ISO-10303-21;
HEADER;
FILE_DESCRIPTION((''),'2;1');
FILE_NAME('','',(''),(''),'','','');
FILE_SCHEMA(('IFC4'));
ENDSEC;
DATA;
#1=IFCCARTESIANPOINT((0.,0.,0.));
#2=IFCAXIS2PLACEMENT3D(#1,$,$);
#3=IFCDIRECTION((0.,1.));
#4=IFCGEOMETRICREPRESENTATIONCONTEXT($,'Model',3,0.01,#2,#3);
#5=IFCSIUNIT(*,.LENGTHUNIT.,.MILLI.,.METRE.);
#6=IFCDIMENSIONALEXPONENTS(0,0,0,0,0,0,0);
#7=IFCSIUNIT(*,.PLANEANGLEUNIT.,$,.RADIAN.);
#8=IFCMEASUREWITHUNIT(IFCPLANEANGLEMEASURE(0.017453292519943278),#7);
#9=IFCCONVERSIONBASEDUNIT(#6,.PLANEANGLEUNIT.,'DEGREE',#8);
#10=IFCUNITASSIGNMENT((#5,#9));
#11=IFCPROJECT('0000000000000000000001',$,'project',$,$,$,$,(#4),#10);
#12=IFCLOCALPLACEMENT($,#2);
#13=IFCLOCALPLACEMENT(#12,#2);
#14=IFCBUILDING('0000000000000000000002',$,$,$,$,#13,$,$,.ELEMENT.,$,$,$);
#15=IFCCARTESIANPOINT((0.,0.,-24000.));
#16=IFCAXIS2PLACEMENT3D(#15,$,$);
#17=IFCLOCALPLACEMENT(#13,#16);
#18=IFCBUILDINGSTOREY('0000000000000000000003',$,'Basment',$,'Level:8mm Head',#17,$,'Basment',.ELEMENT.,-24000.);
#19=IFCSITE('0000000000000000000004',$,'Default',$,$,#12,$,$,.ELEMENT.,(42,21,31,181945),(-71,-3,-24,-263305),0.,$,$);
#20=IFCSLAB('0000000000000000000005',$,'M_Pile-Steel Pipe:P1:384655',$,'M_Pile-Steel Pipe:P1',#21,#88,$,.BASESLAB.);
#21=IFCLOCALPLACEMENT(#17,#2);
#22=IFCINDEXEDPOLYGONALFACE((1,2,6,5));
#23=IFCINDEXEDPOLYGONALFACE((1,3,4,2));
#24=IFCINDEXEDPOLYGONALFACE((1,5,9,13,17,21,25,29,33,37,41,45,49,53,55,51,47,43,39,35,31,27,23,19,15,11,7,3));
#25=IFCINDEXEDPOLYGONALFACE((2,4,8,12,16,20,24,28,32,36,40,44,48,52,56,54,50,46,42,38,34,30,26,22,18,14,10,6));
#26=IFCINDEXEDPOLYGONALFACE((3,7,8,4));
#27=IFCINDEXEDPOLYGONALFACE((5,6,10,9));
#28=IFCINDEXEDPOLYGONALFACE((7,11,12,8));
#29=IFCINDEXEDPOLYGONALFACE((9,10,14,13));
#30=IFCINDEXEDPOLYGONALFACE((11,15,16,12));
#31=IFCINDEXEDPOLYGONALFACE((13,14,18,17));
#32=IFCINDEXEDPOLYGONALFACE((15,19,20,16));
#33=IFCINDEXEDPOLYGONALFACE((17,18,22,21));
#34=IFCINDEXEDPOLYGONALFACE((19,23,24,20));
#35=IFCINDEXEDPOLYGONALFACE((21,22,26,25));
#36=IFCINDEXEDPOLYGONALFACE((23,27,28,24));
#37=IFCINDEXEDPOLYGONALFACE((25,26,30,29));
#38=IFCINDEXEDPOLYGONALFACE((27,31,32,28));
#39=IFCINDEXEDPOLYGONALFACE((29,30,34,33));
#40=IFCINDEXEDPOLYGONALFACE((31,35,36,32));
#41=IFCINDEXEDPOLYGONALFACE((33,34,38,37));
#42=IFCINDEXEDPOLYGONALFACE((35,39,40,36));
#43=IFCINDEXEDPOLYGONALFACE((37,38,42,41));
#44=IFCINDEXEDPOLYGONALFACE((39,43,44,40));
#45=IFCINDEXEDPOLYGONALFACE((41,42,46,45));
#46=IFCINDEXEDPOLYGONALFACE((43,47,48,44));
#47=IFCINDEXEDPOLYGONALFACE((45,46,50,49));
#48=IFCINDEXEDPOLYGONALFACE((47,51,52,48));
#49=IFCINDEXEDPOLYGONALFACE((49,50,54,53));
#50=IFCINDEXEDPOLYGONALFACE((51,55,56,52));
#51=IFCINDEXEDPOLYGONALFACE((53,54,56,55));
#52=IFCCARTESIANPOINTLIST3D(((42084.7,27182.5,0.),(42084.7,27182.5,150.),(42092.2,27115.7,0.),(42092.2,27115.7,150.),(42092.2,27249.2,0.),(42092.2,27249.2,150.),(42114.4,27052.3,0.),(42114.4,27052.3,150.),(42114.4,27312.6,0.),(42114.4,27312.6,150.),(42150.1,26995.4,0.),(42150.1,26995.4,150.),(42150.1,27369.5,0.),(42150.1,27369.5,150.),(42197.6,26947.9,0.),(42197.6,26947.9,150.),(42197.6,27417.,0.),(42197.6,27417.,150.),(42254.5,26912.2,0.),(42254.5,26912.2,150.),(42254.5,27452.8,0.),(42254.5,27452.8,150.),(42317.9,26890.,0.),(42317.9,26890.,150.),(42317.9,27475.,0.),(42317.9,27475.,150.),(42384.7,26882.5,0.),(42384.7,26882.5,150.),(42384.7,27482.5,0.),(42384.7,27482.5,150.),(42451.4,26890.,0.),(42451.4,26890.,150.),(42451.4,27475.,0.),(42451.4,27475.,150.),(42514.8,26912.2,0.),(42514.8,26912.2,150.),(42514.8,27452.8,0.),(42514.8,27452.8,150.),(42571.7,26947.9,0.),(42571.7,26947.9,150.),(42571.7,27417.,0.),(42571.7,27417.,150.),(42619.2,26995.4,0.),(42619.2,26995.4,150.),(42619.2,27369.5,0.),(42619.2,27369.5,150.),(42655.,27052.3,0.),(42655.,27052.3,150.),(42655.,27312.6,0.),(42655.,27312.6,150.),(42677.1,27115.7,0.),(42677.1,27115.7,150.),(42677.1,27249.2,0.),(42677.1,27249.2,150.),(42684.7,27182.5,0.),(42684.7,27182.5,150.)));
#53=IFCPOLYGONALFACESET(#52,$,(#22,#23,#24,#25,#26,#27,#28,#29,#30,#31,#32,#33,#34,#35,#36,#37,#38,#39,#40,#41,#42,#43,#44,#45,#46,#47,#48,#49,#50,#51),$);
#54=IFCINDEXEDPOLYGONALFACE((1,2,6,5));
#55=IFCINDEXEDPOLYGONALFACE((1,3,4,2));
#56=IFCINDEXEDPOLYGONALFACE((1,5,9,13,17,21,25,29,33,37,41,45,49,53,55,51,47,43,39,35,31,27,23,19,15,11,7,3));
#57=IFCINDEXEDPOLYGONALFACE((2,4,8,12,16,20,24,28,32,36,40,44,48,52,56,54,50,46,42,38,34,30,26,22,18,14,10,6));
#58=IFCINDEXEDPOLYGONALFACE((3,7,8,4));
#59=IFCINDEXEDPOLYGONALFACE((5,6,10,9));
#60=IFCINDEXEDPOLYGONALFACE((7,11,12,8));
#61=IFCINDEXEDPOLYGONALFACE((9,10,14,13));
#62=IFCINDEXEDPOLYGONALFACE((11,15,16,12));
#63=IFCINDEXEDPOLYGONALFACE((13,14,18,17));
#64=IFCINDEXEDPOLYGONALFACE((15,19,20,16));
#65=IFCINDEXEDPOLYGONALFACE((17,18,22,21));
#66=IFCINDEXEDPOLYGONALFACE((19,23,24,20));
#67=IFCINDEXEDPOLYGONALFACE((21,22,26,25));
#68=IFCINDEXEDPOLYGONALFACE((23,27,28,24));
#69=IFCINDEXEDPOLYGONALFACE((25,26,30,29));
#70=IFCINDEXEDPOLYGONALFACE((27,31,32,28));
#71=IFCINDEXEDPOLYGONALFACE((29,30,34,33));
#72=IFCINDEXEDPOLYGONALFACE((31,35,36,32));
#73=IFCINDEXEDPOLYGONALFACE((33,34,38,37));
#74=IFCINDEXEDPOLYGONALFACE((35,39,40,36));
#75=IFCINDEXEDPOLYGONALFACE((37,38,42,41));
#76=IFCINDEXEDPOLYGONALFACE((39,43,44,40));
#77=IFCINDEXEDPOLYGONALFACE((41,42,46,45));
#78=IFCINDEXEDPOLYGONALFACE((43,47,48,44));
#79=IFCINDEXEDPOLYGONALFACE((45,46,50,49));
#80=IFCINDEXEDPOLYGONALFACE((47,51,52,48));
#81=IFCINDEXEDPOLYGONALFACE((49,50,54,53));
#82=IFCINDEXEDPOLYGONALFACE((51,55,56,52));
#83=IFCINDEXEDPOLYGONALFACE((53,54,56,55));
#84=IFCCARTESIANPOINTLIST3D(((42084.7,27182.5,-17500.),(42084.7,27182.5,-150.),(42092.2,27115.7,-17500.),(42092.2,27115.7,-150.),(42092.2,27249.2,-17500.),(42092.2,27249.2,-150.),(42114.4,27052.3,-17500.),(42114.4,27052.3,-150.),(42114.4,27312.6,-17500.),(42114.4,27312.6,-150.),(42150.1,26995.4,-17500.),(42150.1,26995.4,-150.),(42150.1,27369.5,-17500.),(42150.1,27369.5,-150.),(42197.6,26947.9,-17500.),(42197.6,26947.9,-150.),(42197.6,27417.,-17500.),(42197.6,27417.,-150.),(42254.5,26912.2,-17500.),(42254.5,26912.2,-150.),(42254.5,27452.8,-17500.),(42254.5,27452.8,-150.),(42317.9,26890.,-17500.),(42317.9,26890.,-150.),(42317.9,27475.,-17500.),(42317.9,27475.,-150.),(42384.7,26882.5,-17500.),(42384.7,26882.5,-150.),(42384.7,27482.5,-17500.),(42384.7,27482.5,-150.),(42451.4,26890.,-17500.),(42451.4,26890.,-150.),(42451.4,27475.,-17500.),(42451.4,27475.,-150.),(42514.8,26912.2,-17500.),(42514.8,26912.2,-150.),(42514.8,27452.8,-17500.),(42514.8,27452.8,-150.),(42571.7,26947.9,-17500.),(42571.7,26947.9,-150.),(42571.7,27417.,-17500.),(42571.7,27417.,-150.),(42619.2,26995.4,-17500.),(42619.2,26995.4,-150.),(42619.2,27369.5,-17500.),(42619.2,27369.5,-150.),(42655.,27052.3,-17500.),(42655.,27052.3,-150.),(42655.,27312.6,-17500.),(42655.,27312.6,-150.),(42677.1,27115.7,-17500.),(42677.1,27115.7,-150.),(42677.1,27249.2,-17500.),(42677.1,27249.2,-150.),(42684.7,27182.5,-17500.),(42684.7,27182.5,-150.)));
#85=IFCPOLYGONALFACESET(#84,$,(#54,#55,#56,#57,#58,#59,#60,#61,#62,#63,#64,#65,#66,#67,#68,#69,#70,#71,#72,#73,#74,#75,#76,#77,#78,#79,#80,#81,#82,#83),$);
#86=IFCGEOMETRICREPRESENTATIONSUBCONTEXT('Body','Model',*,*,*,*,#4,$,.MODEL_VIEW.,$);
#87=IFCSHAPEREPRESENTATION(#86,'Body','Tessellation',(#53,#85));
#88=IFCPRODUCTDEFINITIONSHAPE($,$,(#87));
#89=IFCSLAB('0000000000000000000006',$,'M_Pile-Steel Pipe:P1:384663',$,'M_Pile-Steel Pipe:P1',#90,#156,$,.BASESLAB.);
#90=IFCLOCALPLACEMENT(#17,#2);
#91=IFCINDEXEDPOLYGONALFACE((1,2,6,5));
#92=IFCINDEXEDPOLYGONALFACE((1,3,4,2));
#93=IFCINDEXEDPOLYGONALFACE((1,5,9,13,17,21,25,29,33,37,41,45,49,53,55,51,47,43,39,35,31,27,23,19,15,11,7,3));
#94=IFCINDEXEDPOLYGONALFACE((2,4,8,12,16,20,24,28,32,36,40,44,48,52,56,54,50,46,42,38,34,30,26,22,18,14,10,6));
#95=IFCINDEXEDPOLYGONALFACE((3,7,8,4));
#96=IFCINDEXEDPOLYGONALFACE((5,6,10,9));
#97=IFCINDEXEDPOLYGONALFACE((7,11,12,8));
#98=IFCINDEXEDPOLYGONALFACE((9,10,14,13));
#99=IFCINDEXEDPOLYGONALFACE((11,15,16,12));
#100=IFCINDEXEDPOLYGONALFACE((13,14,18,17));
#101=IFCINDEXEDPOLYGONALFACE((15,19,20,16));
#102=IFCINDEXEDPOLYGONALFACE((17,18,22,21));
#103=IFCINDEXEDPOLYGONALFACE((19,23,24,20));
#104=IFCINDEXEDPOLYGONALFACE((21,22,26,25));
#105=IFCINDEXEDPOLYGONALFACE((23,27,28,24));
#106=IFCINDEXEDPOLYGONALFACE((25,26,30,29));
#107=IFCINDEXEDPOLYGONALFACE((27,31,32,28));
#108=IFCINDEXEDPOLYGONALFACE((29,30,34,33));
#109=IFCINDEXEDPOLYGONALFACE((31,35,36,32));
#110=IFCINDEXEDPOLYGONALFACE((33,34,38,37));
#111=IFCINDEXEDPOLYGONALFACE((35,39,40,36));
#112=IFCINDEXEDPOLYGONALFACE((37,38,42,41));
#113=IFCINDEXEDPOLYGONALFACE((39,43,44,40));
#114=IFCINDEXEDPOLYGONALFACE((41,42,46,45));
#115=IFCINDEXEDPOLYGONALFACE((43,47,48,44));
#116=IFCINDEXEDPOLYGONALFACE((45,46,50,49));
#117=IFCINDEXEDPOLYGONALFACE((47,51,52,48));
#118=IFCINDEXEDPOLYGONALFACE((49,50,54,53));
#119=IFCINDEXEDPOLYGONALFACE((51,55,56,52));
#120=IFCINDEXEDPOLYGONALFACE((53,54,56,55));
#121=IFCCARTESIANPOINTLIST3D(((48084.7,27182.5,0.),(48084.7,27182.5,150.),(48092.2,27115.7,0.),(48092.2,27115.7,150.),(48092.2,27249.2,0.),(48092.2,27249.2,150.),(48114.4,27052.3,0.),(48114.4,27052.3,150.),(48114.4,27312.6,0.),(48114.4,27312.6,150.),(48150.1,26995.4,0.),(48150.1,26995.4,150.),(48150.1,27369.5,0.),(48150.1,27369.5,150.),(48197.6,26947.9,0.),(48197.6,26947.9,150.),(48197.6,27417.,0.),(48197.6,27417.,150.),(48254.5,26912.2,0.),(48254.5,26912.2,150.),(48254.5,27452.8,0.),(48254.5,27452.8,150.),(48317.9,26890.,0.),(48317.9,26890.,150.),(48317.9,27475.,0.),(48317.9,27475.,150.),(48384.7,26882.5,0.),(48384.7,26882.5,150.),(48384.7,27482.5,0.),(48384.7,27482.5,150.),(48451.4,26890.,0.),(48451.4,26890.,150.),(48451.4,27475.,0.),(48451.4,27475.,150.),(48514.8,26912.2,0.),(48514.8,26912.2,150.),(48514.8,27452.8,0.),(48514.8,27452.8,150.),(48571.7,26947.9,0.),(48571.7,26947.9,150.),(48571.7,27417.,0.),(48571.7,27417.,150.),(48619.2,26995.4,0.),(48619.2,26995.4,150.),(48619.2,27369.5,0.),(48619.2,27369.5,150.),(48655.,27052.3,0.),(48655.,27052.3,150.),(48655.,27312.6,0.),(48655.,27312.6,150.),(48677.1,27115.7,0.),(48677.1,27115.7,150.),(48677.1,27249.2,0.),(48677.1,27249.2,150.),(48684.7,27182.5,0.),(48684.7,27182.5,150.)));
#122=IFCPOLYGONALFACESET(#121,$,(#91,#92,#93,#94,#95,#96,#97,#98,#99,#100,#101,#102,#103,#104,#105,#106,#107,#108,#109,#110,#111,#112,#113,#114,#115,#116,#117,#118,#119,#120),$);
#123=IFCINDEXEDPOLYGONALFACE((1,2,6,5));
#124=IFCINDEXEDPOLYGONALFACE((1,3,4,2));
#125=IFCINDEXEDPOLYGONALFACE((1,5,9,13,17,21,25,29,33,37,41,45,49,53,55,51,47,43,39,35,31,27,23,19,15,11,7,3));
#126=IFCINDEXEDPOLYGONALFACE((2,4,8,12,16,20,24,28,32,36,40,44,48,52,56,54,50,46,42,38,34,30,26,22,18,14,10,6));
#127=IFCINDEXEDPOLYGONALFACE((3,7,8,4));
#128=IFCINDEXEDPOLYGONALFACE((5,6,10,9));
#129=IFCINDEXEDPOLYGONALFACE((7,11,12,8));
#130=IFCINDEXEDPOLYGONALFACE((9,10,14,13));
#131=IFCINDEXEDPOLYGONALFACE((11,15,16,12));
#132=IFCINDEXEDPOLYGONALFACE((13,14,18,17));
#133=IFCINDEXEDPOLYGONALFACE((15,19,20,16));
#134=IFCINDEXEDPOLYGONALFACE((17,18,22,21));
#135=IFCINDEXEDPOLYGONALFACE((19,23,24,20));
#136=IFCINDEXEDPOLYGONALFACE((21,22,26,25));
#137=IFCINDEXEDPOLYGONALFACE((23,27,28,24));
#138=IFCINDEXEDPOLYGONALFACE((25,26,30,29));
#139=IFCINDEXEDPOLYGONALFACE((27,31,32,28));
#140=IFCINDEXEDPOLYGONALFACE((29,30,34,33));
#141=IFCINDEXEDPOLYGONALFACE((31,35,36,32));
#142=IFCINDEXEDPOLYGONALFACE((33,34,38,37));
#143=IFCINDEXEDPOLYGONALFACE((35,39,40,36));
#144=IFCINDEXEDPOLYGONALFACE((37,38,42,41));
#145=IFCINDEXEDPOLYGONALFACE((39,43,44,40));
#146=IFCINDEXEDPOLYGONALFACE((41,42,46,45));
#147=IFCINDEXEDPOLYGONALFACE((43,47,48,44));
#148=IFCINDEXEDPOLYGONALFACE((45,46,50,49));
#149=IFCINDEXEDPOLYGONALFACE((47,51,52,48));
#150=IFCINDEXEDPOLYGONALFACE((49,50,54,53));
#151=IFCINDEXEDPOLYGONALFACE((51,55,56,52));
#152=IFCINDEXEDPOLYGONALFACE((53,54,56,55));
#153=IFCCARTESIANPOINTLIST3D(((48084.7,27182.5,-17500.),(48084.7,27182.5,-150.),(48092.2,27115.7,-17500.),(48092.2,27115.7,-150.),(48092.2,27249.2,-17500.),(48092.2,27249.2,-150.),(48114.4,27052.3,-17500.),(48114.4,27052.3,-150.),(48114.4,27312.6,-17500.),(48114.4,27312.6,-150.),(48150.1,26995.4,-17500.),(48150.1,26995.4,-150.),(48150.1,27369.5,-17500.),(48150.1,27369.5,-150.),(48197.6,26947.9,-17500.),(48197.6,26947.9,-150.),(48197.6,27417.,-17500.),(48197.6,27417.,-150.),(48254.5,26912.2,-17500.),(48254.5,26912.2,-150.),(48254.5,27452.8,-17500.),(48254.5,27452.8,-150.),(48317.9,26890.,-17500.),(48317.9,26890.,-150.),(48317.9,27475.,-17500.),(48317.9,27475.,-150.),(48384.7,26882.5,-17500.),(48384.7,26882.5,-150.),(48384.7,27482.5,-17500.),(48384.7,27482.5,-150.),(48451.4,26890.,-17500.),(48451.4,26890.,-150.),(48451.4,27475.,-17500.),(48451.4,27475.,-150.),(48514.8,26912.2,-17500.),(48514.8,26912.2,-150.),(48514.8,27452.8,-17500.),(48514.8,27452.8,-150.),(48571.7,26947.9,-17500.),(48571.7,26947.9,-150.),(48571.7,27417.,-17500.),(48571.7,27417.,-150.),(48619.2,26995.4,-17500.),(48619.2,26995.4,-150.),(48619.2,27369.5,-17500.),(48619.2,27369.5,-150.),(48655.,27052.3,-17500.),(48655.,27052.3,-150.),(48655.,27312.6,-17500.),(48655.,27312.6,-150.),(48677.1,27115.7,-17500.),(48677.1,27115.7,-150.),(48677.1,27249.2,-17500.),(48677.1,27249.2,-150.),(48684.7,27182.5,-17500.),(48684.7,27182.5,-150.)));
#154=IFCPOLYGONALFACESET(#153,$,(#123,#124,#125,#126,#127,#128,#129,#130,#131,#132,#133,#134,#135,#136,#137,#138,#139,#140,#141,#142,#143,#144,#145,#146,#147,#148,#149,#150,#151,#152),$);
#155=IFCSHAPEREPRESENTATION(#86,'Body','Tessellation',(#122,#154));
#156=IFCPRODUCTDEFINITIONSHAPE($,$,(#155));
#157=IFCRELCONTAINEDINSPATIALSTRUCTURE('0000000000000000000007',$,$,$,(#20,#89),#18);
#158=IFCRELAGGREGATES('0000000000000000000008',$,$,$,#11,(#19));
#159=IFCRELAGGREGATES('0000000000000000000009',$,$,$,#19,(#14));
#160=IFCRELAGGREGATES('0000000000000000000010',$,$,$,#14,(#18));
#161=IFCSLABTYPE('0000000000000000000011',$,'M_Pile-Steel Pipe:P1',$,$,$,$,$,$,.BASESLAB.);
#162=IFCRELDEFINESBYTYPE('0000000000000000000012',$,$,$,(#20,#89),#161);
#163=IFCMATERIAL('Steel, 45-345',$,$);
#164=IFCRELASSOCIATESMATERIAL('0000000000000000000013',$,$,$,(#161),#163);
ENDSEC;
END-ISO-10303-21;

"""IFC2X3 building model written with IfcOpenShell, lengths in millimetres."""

from ifc_helpers import new_model, entity, si_unit, converted_unit, direction, frame, origin, origin_2d_with_axis, place, context, subcontext, project, spatial, circle, extrude, material, type_object, element, save


model = new_model("IFC2X3")

# Units and contexts
model_context = context("Model", 3, precision=0.01, world=origin(), true_north=direction((0.0, 1.0)))
body_context = subcontext(model_context, "Body", "Model", "MODEL_VIEW")
ifc_project = project(units=[si_unit("LENGTHUNIT", "METRE", prefix="MILLI"), converted_unit("PLANEANGLEUNIT", "DEGREE", entity("IfcPlaneAngleMeasure", 0.017453292519943278), si_unit("PLANEANGLEUNIT", "RADIAN"), dimensions=[0, 0, 0, 0, 0, 0, 0])], contexts=[model_context])

# Site, building, storey
site_placement = place(None, origin())
site = spatial("IfcSite", under=ifc_project, at=site_placement, Name="Default", CompositionType="ELEMENT", RefLatitude=(42, 21, 31, 181945), RefLongitude=(-71, -3, -24, -263305), RefElevation=0.0)
building_placement = place(site_placement, origin())
building = spatial("IfcBuilding", under=site, at=building_placement, CompositionType="ELEMENT")
storey_placement = place(building_placement, frame((0.0, 0.0, -24000.0)))
storey = spatial("IfcBuildingStorey", under=building, at=storey_placement, Name="Basment", ObjectType="Level:8mm Head", LongName="Basment", CompositionType="ELEMENT", Elevation=-24000.0)

# Slabs
ifc_material_1 = material(Name="Steel, 45-345")
slab_type_1 = type_object("IfcSlabType", Name="M_Pile-Steel Pipe:P1", PredefinedType="BASESLAB", material=ifc_material_1)
slab_1_placement = place(storey_placement, origin())
element("IfcSlab", 1, at=slab_1_placement, inside=storey, type_object=slab_type_1, Name="M_Pile-Steel Pipe:P1:384655", ObjectType="M_Pile-Steel Pipe:P1", PredefinedType="BASESLAB", context=body_context, shape_type="SweptSolid", body=[
    extrude(circle(Radius=300.0, at=origin_2d_with_axis()), frame((42384.7, 27182.5, 0.0), z_axis=(0.0, 0.0, 1.0), x_axis=(0.0, 1.0, 0.0)), (0.0, 0.0, 1.0), 150.0),
    extrude(circle(Radius=300.0, at=origin_2d_with_axis()), frame((42384.7, 27182.5, -17500.0), z_axis=(0.0, 0.0, 1.0), x_axis=(0.0, 1.0, 0.0)), (0.0, 0.0, 1.0), 17350.0),
])
slab_2_placement = place(storey_placement, origin())
element("IfcSlab", 2, at=slab_2_placement, inside=storey, type_object=slab_type_1, Name="M_Pile-Steel Pipe:P1:384663", ObjectType="M_Pile-Steel Pipe:P1", PredefinedType="BASESLAB", context=body_context, shape_type="SweptSolid", body=[
    extrude(circle(Radius=300.0, at=origin_2d_with_axis()), frame((48384.7, 27182.5, 0.0), z_axis=(0.0, 0.0, 1.0), x_axis=(0.0, 1.0, 0.0)), (0.0, 0.0, 1.0), 150.0),
    extrude(circle(Radius=300.0, at=origin_2d_with_axis()), frame((48384.7, 27182.5, -17500.0), z_axis=(0.0, 0.0, 1.0), x_axis=(0.0, 1.0, 0.0)), (0.0, 0.0, 1.0), 17350.0),
])

save(model, "model.ifc")
